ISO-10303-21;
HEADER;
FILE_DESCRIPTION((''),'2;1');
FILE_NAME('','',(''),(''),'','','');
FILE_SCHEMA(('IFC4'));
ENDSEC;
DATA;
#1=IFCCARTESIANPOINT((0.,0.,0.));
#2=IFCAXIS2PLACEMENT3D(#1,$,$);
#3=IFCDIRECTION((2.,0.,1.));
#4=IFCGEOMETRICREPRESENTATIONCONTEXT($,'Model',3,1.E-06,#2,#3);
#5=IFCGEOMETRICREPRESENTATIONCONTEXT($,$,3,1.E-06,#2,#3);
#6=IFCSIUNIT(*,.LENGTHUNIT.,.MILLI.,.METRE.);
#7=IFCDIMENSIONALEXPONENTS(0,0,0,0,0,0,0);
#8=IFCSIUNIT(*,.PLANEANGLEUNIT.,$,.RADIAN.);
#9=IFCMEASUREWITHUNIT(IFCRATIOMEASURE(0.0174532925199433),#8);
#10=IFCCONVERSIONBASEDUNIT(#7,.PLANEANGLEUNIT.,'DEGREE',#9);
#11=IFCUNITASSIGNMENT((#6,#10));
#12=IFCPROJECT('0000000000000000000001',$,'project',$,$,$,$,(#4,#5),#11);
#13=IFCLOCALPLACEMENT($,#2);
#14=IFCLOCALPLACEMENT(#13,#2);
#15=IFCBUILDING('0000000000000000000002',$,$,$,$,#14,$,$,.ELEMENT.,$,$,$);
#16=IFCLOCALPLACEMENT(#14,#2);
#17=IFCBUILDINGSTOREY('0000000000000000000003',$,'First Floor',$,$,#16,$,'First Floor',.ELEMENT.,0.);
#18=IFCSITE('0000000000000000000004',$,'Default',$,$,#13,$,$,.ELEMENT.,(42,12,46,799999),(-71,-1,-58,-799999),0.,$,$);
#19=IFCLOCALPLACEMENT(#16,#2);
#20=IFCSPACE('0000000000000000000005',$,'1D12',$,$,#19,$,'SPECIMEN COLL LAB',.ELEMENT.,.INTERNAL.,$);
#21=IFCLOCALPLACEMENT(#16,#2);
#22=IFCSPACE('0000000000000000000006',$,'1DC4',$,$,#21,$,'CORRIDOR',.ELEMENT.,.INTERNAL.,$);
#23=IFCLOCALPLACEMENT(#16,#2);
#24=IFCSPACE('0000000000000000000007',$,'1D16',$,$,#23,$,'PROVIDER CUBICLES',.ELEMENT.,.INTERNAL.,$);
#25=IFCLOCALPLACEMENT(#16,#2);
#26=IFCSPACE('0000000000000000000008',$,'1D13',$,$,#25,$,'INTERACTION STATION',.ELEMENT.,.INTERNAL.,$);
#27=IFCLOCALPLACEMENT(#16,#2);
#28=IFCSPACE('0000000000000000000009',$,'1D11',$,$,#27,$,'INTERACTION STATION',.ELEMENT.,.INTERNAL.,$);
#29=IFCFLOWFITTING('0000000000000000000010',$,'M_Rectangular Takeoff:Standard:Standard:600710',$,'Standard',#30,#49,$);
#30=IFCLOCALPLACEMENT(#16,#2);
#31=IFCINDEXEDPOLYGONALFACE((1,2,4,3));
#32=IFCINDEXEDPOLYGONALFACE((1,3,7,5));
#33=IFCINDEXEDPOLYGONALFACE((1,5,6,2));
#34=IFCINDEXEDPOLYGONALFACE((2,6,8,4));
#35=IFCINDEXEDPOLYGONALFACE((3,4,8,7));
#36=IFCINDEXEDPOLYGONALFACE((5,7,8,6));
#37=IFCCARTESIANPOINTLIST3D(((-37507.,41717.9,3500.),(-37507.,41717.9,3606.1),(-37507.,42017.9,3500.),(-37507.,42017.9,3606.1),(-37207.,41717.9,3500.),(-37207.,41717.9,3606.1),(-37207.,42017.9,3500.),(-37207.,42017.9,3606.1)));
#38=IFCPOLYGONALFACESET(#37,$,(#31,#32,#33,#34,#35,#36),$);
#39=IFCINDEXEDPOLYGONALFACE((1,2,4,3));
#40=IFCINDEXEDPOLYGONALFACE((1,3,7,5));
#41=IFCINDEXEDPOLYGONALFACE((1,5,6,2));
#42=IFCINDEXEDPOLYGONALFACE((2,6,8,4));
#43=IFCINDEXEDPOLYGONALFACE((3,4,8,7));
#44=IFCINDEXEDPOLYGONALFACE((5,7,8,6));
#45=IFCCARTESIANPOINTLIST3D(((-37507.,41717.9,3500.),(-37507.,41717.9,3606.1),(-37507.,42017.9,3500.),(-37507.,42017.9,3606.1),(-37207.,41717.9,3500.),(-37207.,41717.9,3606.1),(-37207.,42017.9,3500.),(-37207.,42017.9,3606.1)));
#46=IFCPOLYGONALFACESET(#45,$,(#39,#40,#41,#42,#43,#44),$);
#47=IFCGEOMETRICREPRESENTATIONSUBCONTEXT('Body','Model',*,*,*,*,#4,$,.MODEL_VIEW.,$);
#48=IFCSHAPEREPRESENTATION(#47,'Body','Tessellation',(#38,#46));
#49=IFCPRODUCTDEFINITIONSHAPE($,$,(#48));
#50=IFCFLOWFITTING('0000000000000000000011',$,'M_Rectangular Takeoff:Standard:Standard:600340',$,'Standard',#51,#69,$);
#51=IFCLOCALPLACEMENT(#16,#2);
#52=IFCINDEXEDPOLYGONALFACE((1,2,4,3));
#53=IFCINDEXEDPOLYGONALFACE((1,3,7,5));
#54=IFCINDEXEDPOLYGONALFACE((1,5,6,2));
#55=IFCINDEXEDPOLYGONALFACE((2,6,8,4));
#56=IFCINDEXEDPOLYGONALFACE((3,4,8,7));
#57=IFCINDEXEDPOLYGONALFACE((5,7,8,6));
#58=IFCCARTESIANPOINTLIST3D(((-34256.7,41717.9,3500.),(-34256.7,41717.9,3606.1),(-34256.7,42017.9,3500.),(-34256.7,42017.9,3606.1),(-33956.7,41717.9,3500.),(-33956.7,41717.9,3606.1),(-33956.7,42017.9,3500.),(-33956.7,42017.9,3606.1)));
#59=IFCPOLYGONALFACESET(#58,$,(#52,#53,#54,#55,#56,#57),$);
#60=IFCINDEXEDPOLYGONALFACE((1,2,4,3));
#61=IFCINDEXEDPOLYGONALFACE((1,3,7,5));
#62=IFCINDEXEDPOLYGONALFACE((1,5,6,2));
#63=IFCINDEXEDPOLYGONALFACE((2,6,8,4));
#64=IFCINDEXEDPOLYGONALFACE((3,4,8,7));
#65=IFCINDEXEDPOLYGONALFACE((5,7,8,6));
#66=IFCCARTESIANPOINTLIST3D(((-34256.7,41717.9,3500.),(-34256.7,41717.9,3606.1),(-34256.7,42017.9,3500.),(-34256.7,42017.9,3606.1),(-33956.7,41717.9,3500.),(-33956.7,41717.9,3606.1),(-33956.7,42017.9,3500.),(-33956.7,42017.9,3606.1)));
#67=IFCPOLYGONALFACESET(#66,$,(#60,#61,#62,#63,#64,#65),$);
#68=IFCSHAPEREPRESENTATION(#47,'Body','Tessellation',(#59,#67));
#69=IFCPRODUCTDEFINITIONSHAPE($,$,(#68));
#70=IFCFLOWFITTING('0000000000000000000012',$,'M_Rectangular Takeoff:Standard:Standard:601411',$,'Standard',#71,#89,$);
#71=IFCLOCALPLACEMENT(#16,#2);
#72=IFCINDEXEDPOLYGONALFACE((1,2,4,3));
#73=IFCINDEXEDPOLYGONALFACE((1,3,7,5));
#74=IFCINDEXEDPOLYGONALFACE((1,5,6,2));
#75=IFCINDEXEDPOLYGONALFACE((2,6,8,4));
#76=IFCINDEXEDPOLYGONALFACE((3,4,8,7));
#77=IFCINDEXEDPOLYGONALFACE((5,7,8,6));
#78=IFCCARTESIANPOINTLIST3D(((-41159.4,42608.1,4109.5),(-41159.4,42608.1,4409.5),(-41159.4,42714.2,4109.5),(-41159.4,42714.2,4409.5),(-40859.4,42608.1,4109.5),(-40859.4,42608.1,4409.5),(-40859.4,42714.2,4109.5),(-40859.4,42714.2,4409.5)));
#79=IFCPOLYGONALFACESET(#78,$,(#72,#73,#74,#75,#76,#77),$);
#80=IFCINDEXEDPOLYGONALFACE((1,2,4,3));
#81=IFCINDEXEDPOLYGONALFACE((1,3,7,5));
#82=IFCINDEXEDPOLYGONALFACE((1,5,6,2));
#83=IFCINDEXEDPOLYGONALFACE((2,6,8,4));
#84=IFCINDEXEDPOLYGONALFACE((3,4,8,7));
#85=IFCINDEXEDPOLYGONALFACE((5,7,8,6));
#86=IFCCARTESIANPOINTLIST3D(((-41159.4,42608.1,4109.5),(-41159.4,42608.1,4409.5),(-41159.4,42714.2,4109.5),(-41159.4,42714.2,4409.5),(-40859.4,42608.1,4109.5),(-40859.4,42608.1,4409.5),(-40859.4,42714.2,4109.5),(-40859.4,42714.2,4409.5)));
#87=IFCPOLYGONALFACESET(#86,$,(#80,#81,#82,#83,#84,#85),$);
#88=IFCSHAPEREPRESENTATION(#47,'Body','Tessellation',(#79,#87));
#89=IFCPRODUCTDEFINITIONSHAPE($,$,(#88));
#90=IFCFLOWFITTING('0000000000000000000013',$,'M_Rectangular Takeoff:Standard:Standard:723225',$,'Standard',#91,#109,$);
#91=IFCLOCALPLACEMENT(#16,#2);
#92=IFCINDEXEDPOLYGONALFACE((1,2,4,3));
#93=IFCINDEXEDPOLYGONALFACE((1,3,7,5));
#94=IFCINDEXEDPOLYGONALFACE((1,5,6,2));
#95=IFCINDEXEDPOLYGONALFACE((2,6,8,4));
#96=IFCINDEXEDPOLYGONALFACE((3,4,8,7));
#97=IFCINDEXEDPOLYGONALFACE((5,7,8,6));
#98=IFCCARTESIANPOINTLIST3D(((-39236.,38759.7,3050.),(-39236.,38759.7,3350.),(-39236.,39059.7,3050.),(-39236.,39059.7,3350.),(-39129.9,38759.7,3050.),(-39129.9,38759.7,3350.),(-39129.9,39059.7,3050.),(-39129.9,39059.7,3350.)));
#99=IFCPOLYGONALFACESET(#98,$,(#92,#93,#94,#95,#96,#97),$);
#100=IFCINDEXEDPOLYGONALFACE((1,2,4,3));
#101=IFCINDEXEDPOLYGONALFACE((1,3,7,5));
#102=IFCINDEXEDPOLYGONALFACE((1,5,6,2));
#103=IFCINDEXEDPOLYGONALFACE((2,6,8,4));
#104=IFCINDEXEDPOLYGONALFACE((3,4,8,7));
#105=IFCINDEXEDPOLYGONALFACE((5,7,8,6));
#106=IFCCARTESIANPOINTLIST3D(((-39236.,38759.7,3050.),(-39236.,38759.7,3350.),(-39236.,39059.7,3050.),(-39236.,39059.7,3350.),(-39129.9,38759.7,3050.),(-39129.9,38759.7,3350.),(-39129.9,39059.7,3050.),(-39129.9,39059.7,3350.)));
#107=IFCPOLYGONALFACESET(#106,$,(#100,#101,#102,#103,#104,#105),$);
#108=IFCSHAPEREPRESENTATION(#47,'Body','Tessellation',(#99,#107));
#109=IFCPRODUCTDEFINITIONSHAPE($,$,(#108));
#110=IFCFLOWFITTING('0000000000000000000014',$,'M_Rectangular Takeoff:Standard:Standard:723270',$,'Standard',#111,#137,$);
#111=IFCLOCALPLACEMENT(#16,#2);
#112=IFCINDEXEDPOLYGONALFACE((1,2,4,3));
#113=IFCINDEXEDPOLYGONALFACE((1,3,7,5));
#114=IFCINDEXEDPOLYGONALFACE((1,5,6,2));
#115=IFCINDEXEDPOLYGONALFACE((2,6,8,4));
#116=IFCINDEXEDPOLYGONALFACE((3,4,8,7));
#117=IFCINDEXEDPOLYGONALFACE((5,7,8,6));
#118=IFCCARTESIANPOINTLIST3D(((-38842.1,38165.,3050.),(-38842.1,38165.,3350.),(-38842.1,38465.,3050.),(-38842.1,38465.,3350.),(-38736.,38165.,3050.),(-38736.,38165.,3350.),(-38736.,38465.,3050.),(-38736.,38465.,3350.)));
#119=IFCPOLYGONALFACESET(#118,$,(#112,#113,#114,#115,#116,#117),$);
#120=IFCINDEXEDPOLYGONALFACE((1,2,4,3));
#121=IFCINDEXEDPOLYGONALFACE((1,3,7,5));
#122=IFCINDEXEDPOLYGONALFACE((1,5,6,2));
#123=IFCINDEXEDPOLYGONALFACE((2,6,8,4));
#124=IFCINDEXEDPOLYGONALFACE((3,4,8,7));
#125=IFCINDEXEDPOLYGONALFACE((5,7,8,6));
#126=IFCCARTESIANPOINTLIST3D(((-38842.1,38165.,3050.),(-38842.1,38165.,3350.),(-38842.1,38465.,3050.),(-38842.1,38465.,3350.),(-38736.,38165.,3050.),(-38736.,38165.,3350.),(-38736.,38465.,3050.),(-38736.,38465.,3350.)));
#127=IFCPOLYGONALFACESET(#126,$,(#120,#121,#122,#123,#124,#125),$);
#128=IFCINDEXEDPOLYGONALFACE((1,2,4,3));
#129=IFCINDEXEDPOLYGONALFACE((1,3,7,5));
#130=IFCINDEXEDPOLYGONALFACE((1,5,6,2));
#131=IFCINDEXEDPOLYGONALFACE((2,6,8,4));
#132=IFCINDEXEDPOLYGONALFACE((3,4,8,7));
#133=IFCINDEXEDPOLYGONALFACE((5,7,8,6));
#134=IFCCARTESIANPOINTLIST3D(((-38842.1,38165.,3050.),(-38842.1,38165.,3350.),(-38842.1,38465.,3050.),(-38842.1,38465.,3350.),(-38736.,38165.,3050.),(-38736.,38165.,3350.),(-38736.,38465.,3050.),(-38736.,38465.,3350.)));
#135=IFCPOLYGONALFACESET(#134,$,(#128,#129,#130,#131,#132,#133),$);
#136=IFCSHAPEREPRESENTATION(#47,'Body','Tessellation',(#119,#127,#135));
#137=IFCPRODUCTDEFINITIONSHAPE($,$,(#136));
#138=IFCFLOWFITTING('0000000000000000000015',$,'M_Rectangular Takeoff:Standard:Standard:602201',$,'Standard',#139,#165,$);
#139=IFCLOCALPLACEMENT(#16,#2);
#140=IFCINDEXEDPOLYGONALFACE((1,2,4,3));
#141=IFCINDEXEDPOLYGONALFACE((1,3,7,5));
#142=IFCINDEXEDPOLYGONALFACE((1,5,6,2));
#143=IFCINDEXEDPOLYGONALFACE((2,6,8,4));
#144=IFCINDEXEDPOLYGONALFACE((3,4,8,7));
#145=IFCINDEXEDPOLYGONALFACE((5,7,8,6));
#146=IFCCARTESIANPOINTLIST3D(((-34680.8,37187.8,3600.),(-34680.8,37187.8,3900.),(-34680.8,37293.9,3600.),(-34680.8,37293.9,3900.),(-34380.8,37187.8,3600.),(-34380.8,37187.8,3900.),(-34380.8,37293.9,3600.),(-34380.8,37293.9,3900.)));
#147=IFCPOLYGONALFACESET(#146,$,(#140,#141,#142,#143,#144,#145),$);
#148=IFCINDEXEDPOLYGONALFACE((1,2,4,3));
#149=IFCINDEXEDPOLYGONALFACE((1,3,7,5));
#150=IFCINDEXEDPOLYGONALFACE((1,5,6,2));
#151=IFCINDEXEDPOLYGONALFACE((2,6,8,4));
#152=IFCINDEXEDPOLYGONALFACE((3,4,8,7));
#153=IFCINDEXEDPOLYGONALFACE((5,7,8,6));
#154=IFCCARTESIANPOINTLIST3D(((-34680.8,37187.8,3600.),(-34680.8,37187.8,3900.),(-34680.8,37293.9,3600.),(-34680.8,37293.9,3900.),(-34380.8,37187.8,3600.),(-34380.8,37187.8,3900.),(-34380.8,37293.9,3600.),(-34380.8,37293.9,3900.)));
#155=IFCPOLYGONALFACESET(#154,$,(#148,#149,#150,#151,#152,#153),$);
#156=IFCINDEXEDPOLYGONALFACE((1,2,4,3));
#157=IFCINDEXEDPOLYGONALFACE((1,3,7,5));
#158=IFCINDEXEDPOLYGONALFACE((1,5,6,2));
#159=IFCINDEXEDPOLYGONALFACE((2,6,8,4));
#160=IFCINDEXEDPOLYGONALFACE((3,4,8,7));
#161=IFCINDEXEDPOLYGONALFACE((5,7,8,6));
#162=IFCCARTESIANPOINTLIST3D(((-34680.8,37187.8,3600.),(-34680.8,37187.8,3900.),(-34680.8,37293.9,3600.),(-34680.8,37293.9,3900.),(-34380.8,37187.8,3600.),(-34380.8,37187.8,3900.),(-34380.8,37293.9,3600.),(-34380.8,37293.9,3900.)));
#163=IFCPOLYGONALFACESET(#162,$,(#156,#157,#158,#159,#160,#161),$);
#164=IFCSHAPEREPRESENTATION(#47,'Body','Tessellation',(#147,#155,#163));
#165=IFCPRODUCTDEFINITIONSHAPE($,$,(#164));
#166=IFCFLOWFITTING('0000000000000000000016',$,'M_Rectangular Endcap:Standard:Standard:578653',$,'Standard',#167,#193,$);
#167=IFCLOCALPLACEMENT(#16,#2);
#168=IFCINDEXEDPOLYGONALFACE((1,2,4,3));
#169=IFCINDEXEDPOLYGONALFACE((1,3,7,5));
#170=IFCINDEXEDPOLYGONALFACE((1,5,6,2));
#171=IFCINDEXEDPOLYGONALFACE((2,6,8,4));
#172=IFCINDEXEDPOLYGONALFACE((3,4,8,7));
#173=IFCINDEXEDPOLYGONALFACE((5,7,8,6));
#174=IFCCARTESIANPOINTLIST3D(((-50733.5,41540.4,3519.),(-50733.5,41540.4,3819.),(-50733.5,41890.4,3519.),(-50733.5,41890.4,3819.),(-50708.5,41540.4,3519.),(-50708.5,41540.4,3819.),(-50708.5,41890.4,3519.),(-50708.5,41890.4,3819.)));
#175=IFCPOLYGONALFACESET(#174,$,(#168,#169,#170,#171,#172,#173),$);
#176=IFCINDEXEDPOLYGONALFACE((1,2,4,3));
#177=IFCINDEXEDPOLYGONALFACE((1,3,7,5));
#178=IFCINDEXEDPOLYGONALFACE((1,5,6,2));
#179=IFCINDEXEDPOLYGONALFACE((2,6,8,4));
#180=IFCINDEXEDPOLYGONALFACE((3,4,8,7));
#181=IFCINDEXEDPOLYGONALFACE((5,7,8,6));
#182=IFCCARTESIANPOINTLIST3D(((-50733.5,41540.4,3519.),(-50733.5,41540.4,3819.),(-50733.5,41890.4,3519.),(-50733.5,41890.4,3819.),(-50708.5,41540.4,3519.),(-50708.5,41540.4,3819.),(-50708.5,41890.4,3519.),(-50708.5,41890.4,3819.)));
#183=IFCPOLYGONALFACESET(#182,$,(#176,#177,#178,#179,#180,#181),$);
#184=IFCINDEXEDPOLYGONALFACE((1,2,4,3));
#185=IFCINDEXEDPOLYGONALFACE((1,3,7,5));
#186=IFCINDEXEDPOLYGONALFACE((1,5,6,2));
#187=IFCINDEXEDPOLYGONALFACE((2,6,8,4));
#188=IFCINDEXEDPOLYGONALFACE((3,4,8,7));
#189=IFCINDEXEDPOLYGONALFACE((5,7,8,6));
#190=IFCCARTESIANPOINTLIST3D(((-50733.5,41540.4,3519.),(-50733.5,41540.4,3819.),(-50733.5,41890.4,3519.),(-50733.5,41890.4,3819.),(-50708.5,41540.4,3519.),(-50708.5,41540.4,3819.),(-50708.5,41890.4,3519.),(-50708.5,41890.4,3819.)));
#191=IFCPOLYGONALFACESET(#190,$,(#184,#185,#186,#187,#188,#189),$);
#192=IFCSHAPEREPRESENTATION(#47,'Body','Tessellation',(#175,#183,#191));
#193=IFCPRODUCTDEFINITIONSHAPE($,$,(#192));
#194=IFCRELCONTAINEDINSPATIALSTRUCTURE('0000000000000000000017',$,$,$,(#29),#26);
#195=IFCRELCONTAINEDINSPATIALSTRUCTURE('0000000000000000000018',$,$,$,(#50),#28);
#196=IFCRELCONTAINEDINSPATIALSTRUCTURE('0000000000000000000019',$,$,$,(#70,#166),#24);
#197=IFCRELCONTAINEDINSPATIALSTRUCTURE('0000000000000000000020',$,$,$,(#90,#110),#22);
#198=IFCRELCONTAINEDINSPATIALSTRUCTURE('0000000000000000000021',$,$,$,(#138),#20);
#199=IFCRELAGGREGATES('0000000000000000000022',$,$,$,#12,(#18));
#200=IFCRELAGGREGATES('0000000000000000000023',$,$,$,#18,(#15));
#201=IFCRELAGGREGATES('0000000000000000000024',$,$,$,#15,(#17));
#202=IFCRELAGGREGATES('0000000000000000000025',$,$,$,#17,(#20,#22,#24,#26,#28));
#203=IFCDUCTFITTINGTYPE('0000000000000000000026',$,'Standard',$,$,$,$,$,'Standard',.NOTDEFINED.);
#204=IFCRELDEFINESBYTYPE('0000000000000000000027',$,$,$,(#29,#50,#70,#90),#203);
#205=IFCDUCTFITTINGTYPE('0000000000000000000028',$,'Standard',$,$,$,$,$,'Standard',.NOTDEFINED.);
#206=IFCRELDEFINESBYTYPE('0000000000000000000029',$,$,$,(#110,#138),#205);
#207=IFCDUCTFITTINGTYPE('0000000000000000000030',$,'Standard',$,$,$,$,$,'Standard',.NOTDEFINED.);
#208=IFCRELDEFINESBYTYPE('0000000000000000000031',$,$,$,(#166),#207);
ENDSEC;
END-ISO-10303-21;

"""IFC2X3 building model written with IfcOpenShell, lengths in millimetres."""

from ifc_helpers import new_model, entity, si_unit, converted_unit, direction, frame, frame_2d, origin, origin_2d_with_axis, place, context, subcontext, project, spatial, rectangle, extrude, source, transform, mapped, type_object, type_shapes, element, save


model = new_model("IFC2X3")

# Units and contexts
model_context = context("Model", 3, precision=1e-06, world=origin(), true_north=direction((2.0, 0.0, 1.0)))
context_of_model = context(None, 3, precision=1e-06, world=origin(), true_north=direction((2.0, 0.0, 1.0)))
body_context = subcontext(model_context, "Body", "Model", "MODEL_VIEW")
ifc_project = project(units=[si_unit("LENGTHUNIT", "METRE", prefix="MILLI"), converted_unit("PLANEANGLEUNIT", "DEGREE", entity("IfcRatioMeasure", 0.0174532925199433), si_unit("PLANEANGLEUNIT", "RADIAN"), dimensions=[0, 0, 0, 0, 0, 0, 0])], contexts=[model_context, context_of_model])

# Site, building, storey
site_placement = place(None, origin())
site = spatial("IfcSite", under=ifc_project, at=site_placement, Name="Default", CompositionType="ELEMENT", RefLatitude=(42, 12, 46, 799999), RefLongitude=(-71, -1, -58, -799999), RefElevation=0.0)
building_placement = place(site_placement, origin())
building = spatial("IfcBuilding", under=site, at=building_placement, CompositionType="ELEMENT")
storey_placement = place(building_placement, origin())
storey = spatial("IfcBuildingStorey", under=building, at=storey_placement, Name="First Floor", LongName="First Floor", CompositionType="ELEMENT", Elevation=0.0)

# Shared definitions
space_1_placement = place(storey_placement, origin())
space_1 = spatial("IfcSpace", under=storey, at=space_1_placement, Name="1D12", LongName="SPECIMEN COLL LAB", CompositionType="ELEMENT", InteriorOrExteriorSpace="INTERNAL")

# Shared definitions
space_2_placement = place(storey_placement, origin())
space_2 = spatial("IfcSpace", under=storey, at=space_2_placement, Name="1DC4", LongName="CORRIDOR", CompositionType="ELEMENT", InteriorOrExteriorSpace="INTERNAL")

# Shared definitions
space_3_placement = place(storey_placement, origin())
space_3 = spatial("IfcSpace", under=storey, at=space_3_placement, Name="1D16", LongName="PROVIDER CUBICLES", CompositionType="ELEMENT", InteriorOrExteriorSpace="INTERNAL")

# Shared definitions
space_4_placement = place(storey_placement, origin())
space_4 = spatial("IfcSpace", under=storey, at=space_4_placement, Name="1D13", LongName="INTERACTION STATION", CompositionType="ELEMENT", InteriorOrExteriorSpace="INTERNAL")

# Flow fitting
duct_fitting_type_1 = type_object("IfcDuctFittingType", Name="Standard", ElementType="Standard", PredefinedType="NOTDEFINED")
shared_shape_1 = source(origin(), body_context, "Body", "SweptSolid", [
    extrude(rectangle(XDim=300.0, YDim=106.1, at=frame_2d((0.0, 0.0), x_axis=(1.0, 0.0))), frame((47.0, 0.0, -150.0), z_axis=(0.0, 0.0, 1.0), x_axis=(0.0, -1.0, 0.0)), (0.0, 0.0, 1.0), 300.0),
    extrude(rectangle(XDim=300.0, YDim=106.1, at=frame_2d((0.0, 0.0), x_axis=(1.0, 0.0))), frame((47.0, 0.0, -150.0), z_axis=(0.0, 0.0, 1.0), x_axis=(0.0, -1.0, 0.0)), (0.0, 0.0, 1.0), 300.0),
])
type_shapes(duct_fitting_type_1, [shared_shape_1])
flow_fitting_1_placement = place(space_4_placement, frame((-37357.0, 41867.9, 3600.0), z_axis=(1.0, 0.0, 0.0), x_axis=(0.0, 0.0, -1.0)))
element("IfcFlowFitting", 1, at=flow_fitting_1_placement, inside=space_4, type_object=duct_fitting_type_1, Name="M_Rectangular Takeoff:Standard:Standard:600710", ObjectType="Standard", context=body_context, shape_type="MappedRepresentation", body=[
    mapped(shared_shape_1, transform((0.0, 0.0, 0.0), scale=1.0)),
])

# Shared definitions
space_5_placement = place(storey_placement, origin())
space_5 = spatial("IfcSpace", under=storey, at=space_5_placement, Name="1D11", LongName="INTERACTION STATION", CompositionType="ELEMENT", InteriorOrExteriorSpace="INTERNAL")

# Flow fittings
flow_fitting_2_placement = place(space_5_placement, frame((-34106.7, 41867.9, 3600.0), z_axis=(1.0, 0.0, 0.0), x_axis=(0.0, 0.0, -1.0)))
element("IfcFlowFitting", 2, at=flow_fitting_2_placement, inside=space_5, type_object=duct_fitting_type_1, Name="M_Rectangular Takeoff:Standard:Standard:600340", ObjectType="Standard", context=body_context, shape_type="MappedRepresentation", body=[
    mapped(shared_shape_1, transform((0.0, 0.0, 0.0), scale=1.0)),
])
flow_fitting_3_placement = place(space_3_placement, frame((-41009.4, 42708.1, 4259.5), z_axis=(0.0, 0.0, -1.0), x_axis=(0.0, -1.0, 0.0)))
element("IfcFlowFitting", 3, at=flow_fitting_3_placement, inside=space_3, type_object=duct_fitting_type_1, Name="M_Rectangular Takeoff:Standard:Standard:601411", ObjectType="Standard", context=body_context, shape_type="MappedRepresentation", body=[
    mapped(shared_shape_1, transform((0.0, 0.0, 0.0), scale=1.0)),
])
flow_fitting_4_placement = place(space_2_placement, frame((-39136.0, 38909.7, 3200.0), z_axis=(0.0, 0.0, -1.0), x_axis=(-1.0, 0.0, 0.0)))
element("IfcFlowFitting", 4, at=flow_fitting_4_placement, inside=space_2, type_object=duct_fitting_type_1, Name="M_Rectangular Takeoff:Standard:Standard:723225", ObjectType="Standard", context=body_context, shape_type="MappedRepresentation", body=[
    mapped(shared_shape_1, transform((0.0, 0.0, 0.0), scale=1.0)),
])
duct_fitting_type_2 = type_object("IfcDuctFittingType", Name="Standard", ElementType="Standard", PredefinedType="NOTDEFINED")
shared_shape_2 = source(origin(), body_context, "Body", "SweptSolid", [
    extrude(rectangle(XDim=106.1, YDim=300.0, at=frame_2d((0.0, 0.0), x_axis=(1.0, 0.0))), frame((47.0, 0.0, -150.0)), (0.0, 0.0, 1.0), 300.0),
    extrude(rectangle(XDim=106.1, YDim=300.0, at=frame_2d((0.0, 0.0), x_axis=(1.0, 0.0))), frame((47.0, 0.0, -150.0)), (0.0, 0.0, 1.0), 300.0),
    extrude(rectangle(XDim=106.1, YDim=300.0, at=frame_2d((0.0, 0.0), x_axis=(1.0, 0.0))), frame((47.0, 0.0, -150.0)), (0.0, 0.0, 1.0), 300.0),
])
type_shapes(duct_fitting_type_2, [shared_shape_2])
flow_fitting_5_placement = place(space_2_placement, frame((-38836.0, 38315.0, 3200.0), z_axis=(0.0, 0.0, -1.0), x_axis=(1.0, 0.0, 0.0)))
element("IfcFlowFitting", 5, at=flow_fitting_5_placement, inside=space_2, type_object=duct_fitting_type_2, Name="M_Rectangular Takeoff:Standard:Standard:723270", ObjectType="Standard", context=body_context, shape_type="MappedRepresentation", body=[
    mapped(shared_shape_2, transform((0.0, 0.0, 0.0), scale=1.0)),
])
flow_fitting_6_placement = place(space_1_placement, frame((-34530.8, 37193.9, 3750.0), z_axis=(0.0, 0.0, -1.0), x_axis=(0.0, 1.0, 0.0)))
element("IfcFlowFitting", 6, at=flow_fitting_6_placement, inside=space_1, type_object=duct_fitting_type_2, Name="M_Rectangular Takeoff:Standard:Standard:602201", ObjectType="Standard", context=body_context, shape_type="MappedRepresentation", body=[
    mapped(shared_shape_2, transform((0.0, 0.0, 0.0), scale=1.0)),
])

# Flow fitting
duct_fitting_type_3 = type_object("IfcDuctFittingType", Name="Standard", ElementType="Standard", PredefinedType="NOTDEFINED")
shared_shape_3 = source(origin(), body_context, "Body", "SweptSolid", [
    extrude(rectangle(XDim=25.0, YDim=350.0, at=origin_2d_with_axis()), frame((12.5, 0.0, -150.0)), (0.0, 0.0, 1.0), 300.0),
    extrude(rectangle(XDim=25.0, YDim=350.0, at=origin_2d_with_axis()), frame((12.5, 0.0, -150.0)), (0.0, 0.0, 1.0), 300.0),
    extrude(rectangle(XDim=25.0, YDim=350.0, at=frame_2d((0.0, 0.0), x_axis=(1.0, 0.0))), frame((12.5, 0.0, -150.0)), (0.0, 0.0, 1.0), 300.0),
])
type_shapes(duct_fitting_type_3, [shared_shape_3])
flow_fitting_7_placement = place(space_3_placement, frame((-50708.5, 41715.4, 3669.0), z_axis=(0.0, 0.0, 1.0), x_axis=(-1.0, 0.0, 0.0)))
element("IfcFlowFitting", 7, at=flow_fitting_7_placement, inside=space_3, type_object=duct_fitting_type_3, Name="M_Rectangular Endcap:Standard:Standard:578653", ObjectType="Standard", context=body_context, shape_type="MappedRepresentation", body=[
    mapped(shared_shape_3, transform((0.0, 0.0, 0.0), scale=1.0)),
])

save(model, "model.ifc")
